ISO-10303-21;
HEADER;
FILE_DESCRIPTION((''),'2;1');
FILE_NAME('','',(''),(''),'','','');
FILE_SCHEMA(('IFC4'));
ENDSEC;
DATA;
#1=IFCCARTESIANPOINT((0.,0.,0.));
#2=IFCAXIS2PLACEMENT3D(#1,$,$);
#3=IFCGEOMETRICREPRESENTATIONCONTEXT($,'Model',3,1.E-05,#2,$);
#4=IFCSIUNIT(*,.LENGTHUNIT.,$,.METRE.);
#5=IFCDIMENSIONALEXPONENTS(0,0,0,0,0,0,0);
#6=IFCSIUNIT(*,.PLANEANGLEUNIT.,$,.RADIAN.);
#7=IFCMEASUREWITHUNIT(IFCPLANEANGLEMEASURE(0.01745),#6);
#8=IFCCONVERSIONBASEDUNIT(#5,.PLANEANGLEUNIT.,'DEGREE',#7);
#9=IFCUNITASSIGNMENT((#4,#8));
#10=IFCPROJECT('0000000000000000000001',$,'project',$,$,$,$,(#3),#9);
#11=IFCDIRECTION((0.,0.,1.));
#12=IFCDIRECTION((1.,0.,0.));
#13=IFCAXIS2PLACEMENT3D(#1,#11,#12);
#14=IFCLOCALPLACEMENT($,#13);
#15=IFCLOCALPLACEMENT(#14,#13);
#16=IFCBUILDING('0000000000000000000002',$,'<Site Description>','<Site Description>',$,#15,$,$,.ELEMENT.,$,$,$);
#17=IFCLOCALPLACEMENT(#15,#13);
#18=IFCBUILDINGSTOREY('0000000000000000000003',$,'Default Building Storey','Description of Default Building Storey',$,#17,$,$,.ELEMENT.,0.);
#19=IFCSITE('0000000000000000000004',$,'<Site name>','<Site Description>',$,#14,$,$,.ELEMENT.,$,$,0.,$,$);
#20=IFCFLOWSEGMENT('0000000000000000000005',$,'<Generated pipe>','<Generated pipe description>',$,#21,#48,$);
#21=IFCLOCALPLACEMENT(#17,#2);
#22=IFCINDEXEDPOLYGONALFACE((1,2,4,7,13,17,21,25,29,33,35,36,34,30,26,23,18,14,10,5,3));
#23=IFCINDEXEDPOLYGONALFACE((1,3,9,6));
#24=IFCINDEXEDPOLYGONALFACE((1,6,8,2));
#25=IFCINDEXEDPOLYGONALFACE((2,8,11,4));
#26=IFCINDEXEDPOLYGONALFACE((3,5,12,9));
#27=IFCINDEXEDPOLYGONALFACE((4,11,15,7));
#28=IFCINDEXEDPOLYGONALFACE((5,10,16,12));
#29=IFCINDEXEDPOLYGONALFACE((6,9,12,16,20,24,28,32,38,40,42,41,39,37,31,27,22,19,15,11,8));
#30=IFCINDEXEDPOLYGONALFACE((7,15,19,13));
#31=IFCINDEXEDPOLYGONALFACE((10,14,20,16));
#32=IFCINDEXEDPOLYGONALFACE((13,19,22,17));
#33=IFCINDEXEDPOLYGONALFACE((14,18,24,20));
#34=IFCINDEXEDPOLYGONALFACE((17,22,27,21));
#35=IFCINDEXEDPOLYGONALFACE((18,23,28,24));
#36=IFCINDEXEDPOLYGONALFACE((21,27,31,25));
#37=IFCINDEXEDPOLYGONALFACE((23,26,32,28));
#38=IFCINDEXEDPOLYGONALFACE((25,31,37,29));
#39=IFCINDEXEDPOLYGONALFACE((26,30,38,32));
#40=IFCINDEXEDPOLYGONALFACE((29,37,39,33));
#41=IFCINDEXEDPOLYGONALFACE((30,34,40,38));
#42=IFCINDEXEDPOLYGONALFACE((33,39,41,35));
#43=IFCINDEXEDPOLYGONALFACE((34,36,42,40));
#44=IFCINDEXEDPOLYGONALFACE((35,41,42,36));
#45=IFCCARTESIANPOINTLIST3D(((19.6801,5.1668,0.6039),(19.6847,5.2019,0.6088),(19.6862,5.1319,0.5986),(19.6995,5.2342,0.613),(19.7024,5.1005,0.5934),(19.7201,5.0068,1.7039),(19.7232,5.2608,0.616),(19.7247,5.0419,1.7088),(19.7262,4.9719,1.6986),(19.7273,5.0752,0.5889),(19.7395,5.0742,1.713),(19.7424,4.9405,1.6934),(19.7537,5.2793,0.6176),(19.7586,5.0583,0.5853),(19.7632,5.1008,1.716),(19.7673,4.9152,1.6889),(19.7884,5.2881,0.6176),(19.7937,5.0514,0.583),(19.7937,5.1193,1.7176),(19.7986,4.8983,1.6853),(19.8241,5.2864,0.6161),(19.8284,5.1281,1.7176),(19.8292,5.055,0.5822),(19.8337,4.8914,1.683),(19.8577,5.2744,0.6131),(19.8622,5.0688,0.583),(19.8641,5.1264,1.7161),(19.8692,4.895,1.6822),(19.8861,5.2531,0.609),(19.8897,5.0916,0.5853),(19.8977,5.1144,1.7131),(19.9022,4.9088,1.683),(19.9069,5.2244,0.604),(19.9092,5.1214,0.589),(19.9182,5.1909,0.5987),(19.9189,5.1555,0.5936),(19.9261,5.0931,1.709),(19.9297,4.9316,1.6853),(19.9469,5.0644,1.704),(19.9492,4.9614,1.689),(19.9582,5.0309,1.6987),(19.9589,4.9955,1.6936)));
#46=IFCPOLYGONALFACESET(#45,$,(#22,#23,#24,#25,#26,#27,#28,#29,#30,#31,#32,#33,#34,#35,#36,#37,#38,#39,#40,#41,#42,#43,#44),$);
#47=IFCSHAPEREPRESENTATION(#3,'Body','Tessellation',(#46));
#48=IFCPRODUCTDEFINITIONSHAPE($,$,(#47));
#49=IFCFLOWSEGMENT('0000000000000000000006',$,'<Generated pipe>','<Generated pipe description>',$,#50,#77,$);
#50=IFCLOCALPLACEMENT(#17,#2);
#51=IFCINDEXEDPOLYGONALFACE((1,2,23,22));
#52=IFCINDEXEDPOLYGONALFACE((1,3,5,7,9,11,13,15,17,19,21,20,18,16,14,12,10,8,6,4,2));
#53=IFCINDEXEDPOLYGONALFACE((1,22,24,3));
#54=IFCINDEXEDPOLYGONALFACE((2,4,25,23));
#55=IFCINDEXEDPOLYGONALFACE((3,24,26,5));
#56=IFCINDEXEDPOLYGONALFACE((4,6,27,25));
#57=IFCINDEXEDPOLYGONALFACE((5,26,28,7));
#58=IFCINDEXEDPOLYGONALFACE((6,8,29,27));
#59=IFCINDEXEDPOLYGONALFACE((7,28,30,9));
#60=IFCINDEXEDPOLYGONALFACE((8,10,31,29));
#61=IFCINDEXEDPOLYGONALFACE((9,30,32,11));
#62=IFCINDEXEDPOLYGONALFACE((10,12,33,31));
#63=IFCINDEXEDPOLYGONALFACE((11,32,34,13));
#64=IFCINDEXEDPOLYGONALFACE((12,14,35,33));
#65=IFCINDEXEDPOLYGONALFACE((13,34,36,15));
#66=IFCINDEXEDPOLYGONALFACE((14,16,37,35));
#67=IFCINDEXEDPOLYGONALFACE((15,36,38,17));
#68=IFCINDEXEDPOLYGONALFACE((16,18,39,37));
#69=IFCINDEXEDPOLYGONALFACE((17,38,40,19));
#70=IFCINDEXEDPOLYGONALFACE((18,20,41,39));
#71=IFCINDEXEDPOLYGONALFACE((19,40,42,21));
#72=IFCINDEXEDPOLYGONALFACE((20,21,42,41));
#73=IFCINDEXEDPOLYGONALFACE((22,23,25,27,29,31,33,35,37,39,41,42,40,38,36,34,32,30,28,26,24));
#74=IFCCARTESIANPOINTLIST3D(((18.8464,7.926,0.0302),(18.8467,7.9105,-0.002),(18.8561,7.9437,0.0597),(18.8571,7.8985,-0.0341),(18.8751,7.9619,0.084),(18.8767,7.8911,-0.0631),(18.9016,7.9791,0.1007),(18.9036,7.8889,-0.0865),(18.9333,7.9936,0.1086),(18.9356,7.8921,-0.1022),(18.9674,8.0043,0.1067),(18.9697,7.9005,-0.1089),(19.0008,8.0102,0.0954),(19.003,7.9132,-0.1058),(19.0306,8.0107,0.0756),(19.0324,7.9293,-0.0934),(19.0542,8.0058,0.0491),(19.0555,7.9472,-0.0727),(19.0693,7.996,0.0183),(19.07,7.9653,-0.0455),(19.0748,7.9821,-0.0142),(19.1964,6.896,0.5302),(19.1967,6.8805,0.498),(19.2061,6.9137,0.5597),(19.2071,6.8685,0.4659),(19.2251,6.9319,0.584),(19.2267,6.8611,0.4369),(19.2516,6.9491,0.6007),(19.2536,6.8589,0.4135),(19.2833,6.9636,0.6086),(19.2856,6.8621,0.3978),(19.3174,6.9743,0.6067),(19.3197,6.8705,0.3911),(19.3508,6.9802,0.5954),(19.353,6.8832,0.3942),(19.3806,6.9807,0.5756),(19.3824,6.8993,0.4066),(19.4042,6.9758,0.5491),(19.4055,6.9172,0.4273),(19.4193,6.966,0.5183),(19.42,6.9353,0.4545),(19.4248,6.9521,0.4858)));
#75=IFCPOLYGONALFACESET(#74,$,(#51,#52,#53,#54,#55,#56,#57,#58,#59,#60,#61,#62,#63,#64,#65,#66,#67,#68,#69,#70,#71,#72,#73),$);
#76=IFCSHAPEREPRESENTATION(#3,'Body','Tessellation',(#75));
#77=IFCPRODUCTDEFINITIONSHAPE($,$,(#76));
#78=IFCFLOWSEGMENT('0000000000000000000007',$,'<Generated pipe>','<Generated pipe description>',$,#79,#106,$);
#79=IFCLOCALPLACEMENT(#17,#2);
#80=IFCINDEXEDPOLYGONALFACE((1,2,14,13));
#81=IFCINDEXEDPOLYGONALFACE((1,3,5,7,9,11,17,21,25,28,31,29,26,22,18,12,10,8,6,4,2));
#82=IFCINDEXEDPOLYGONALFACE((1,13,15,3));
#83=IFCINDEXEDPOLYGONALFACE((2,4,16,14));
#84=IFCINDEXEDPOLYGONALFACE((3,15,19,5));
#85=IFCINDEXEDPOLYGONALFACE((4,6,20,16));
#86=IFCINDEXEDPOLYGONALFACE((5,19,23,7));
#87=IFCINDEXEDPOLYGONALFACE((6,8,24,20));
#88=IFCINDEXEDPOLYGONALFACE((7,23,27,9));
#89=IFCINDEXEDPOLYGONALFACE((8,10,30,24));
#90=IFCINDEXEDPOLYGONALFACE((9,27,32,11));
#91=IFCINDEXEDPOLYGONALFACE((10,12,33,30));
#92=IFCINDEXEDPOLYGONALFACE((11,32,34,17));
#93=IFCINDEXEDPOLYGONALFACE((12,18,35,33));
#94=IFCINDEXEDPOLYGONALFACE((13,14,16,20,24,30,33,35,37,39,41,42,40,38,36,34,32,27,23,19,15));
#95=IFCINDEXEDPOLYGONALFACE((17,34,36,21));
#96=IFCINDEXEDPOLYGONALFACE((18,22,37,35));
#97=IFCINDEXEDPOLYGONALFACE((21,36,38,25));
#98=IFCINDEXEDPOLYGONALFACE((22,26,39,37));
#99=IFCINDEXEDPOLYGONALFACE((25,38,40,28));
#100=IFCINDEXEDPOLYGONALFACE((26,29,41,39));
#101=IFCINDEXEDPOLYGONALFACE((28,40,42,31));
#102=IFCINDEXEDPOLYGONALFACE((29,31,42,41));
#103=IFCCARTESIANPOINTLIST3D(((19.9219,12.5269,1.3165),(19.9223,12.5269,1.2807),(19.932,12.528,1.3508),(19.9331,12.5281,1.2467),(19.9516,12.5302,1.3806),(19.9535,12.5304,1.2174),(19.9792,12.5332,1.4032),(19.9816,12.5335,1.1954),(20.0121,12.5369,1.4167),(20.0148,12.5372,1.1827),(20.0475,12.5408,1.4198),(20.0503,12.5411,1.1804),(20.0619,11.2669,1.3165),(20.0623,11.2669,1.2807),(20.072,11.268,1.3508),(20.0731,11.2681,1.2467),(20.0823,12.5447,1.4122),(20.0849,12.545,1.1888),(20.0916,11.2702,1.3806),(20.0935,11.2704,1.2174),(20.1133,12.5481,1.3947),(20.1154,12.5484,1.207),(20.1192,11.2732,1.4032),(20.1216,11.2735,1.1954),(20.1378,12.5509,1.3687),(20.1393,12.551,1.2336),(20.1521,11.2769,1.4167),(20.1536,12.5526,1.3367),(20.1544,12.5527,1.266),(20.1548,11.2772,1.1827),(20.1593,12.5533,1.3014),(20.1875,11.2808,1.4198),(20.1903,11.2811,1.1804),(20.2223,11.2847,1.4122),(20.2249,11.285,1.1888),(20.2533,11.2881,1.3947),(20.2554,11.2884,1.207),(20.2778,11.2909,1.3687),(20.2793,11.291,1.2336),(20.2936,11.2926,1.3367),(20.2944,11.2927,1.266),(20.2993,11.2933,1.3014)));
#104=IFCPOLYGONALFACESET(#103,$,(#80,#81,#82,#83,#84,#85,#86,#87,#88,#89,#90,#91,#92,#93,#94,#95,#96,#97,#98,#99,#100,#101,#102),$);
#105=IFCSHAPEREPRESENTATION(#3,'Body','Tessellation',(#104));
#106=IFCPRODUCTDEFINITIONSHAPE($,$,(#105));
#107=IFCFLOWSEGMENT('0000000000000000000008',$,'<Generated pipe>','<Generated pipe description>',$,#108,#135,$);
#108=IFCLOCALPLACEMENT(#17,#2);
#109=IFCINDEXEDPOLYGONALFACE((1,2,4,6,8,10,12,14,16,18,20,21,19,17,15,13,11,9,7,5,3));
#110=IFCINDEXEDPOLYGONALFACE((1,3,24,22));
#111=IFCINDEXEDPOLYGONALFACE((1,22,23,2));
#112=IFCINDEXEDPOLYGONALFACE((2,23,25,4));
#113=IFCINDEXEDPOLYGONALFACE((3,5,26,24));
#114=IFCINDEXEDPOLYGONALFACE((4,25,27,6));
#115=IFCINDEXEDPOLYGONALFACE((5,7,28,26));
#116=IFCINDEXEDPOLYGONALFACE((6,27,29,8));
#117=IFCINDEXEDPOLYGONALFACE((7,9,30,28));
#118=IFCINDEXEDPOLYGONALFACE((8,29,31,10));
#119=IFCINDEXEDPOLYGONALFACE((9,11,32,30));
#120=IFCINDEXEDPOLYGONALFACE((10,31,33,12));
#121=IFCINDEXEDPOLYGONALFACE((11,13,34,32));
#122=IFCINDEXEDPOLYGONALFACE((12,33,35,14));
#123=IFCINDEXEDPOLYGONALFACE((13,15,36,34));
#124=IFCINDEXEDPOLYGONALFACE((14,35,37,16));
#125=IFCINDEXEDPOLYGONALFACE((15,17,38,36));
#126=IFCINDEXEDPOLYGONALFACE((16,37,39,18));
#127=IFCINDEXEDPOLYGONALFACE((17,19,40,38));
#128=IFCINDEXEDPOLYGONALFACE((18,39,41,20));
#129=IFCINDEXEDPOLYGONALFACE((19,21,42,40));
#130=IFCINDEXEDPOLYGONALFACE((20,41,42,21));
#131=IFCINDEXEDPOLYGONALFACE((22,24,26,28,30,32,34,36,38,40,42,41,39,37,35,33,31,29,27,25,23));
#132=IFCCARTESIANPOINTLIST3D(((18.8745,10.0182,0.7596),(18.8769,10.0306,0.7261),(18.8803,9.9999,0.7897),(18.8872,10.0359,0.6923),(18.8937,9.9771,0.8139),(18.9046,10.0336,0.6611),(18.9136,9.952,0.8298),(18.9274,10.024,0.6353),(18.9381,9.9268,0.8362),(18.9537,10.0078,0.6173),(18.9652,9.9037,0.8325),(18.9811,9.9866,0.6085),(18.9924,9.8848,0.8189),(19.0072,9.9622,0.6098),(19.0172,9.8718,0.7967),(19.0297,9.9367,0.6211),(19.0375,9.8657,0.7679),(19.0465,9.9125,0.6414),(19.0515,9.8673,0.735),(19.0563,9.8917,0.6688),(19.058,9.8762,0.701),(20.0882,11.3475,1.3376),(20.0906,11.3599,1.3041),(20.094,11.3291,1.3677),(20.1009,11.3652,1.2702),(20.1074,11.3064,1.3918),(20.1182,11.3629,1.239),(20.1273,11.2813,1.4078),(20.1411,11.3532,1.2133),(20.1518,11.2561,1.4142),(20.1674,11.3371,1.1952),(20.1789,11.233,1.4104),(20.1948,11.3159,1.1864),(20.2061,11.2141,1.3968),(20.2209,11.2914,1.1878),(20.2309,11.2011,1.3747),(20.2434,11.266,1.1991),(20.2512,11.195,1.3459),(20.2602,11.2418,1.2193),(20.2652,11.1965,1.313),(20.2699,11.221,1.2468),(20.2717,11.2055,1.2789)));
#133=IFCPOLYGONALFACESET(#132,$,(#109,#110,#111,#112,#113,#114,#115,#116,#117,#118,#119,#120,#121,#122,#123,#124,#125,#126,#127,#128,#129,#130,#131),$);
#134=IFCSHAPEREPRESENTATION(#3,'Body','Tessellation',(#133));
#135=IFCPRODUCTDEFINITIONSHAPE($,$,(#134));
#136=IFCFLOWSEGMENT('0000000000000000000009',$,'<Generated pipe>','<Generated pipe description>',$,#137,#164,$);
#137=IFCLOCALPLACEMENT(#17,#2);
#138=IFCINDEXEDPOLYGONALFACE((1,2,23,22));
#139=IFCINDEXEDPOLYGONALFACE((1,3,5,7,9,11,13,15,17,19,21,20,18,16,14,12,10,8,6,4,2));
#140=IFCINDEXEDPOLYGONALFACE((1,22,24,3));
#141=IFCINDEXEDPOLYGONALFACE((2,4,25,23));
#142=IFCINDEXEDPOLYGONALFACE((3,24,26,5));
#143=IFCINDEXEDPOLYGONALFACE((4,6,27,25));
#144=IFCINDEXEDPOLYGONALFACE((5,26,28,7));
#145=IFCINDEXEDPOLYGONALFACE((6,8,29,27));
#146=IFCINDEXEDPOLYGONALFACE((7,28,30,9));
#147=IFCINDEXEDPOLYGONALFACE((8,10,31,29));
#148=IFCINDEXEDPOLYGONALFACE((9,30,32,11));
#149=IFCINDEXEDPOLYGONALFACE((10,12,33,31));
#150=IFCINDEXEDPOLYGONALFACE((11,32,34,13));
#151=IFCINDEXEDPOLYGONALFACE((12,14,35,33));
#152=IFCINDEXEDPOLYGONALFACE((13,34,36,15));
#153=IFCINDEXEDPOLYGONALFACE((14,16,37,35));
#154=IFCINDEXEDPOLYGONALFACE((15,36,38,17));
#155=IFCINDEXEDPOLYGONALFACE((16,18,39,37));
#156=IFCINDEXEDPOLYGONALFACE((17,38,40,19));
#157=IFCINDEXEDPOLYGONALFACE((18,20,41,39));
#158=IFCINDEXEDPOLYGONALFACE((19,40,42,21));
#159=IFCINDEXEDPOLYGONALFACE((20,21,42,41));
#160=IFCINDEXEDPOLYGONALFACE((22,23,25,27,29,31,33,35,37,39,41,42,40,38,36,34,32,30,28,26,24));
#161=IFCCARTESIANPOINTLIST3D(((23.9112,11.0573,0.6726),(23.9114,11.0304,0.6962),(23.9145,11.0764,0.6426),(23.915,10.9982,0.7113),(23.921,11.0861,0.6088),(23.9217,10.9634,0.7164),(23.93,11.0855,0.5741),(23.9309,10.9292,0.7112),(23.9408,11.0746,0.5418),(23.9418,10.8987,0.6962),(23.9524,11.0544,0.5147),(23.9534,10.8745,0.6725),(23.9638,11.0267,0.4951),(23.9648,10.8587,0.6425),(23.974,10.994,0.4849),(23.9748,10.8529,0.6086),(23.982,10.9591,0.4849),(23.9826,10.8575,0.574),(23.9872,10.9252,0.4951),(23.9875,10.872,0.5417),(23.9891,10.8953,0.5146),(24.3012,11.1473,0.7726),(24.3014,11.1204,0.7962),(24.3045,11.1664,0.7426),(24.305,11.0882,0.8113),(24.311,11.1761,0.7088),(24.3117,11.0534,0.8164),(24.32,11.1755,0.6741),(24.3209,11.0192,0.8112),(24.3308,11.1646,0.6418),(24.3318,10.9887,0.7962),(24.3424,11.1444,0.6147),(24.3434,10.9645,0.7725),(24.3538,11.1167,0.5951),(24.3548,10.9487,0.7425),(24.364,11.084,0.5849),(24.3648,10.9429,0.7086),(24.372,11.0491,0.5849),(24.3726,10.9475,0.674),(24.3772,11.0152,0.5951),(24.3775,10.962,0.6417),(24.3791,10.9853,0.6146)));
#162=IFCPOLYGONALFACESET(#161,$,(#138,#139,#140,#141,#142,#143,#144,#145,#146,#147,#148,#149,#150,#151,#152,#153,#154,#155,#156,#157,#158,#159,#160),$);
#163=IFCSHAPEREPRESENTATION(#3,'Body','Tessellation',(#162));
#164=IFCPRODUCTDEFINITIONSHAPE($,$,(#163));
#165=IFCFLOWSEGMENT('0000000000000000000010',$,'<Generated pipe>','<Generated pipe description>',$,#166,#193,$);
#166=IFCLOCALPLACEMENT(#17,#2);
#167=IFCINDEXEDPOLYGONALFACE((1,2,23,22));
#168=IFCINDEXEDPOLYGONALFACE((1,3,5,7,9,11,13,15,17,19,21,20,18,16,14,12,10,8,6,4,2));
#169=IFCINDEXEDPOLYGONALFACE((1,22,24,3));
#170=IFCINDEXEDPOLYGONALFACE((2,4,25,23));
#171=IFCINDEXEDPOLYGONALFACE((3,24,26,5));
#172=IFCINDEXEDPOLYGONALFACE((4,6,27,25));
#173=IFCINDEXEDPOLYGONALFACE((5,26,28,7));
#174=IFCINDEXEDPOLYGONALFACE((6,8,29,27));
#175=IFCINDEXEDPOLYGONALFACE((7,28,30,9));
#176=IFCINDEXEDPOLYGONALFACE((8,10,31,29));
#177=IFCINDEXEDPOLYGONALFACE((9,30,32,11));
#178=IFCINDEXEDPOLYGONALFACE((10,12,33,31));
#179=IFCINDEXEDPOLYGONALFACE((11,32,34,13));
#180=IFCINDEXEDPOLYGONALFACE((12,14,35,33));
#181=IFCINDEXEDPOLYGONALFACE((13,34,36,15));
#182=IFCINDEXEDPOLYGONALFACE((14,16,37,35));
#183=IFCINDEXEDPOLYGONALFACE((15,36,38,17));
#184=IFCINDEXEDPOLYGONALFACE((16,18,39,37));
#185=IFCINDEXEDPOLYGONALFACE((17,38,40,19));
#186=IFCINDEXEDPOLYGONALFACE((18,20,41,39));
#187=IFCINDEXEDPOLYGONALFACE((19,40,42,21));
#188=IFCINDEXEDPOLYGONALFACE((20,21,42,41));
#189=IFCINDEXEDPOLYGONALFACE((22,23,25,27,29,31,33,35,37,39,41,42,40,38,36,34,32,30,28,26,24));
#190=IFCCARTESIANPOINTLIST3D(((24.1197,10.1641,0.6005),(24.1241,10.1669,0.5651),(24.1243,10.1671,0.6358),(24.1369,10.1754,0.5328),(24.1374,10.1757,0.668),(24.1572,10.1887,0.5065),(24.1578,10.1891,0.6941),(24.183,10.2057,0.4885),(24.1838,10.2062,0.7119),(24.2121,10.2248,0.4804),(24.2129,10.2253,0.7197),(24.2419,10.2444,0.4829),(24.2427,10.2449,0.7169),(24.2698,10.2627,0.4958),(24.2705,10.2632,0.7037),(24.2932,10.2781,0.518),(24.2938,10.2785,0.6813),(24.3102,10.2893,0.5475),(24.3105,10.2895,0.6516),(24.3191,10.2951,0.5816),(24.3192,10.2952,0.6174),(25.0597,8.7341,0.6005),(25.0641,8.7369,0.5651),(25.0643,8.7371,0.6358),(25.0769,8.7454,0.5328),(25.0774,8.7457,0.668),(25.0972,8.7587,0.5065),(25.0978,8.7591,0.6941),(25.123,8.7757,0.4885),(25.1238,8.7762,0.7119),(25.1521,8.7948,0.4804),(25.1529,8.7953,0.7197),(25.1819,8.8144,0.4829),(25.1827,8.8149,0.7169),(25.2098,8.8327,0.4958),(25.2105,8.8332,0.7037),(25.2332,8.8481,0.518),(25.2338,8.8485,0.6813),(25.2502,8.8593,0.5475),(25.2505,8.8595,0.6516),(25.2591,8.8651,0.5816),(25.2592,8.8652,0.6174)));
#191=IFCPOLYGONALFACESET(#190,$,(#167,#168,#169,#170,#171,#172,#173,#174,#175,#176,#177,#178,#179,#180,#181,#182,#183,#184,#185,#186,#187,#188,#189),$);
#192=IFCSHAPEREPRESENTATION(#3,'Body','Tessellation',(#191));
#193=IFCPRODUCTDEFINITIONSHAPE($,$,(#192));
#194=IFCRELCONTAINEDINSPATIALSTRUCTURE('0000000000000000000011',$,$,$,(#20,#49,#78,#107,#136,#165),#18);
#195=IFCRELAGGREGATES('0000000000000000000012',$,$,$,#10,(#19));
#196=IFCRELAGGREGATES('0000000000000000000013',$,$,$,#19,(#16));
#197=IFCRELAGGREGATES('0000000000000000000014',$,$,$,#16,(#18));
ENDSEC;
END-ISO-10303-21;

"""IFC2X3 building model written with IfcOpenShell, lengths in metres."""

from ifc_helpers import new_model, entity, si_unit, converted_unit, frame, origin, origin_with_axes, origin_2d_with_axis, place, context, project, spatial, circle, extrude, element, save


model = new_model("IFC2X3")

# Units and contexts
model_context = context("Model", 3, precision=1e-05, world=origin())
ifc_project = project(units=[si_unit("LENGTHUNIT", "METRE"), converted_unit("PLANEANGLEUNIT", "DEGREE", entity("IfcPlaneAngleMeasure", 0.01745), si_unit("PLANEANGLEUNIT", "RADIAN"), dimensions=[0, 0, 0, 0, 0, 0, 0])], contexts=[model_context])

# Site, building, storey
site_placement = place(None, origin_with_axes())
site = spatial("IfcSite", under=ifc_project, at=site_placement, Name="<Site name>", Description="<Site Description>", CompositionType="ELEMENT", RefElevation=0.0)
building_placement = place(site_placement, origin_with_axes())
building = spatial("IfcBuilding", under=site, at=building_placement, Name="<Site Description>", Description="<Site Description>", CompositionType="ELEMENT")
storey_placement = place(building_placement, origin_with_axes())
storey = spatial("IfcBuildingStorey", under=building, at=storey_placement, Name="Default Building Storey", Description="Description of Default Building Storey", CompositionType="ELEMENT", Elevation=0.0)

# Flow segments
flow_segment_1_placement = place(storey_placement, frame((19.84, 5.01, 1.7), z_axis=(-0.035962, 0.143847, -0.988946), x_axis=(0.984686, 0.17402, -0.010495)))
element("IfcFlowSegment", 1, at=flow_segment_1_placement, inside=storey, Name="<Generated pipe>", Description="<Generated pipe description>", context=model_context, shape_type="SweptSolid", body=[
    extrude(circle(Radius=0.12, at=origin_2d_with_axis()), origin_with_axes(), (0.0, 0.0, 1.0), 1.1123),
])
flow_segment_2_placement = place(storey_placement, frame((19.31, 6.92, 0.5), z_axis=(-0.292337, 0.860307, -0.417625), x_axis=(0.910945, 0.383426, 0.152197)))
element("IfcFlowSegment", 2, at=flow_segment_2_placement, inside=storey, Name="<Generated pipe>", Description="<Generated pipe description>", context=model_context, shape_type="SweptSolid", body=[
    extrude(circle(Radius=0.12, at=origin_2d_with_axis()), origin_with_axes(), (0.0, 0.0, 1.0), 1.1972),
])
flow_segment_3_placement = place(storey_placement, frame((20.04, 12.54, 1.3), z_axis=(0.110432, -0.993884, 0.0), x_axis=(0.610667, 0.067852, 0.788975)))
element("IfcFlowSegment", 3, at=flow_segment_3_placement, inside=storey, Name="<Generated pipe>", Description="<Generated pipe description>", context=model_context, shape_type="SweptSolid", body=[
    extrude(circle(Radius=0.12, at=origin_2d_with_axis()), origin_with_axes(), (0.0, 0.0, 1.0), 1.2678),
])
flow_segment_4_placement = place(storey_placement, frame((20.18, 11.28, 1.3), z_axis=(-0.641989, -0.703131, -0.305709), x_axis=(-0.439527, 0.010801, 0.898164)))
element("IfcFlowSegment", 4, at=flow_segment_4_placement, inside=storey, Name="<Generated pipe>", Description="<Generated pipe description>", context=model_context, shape_type="SweptSolid", body=[
    extrude(circle(Radius=0.12, at=origin_2d_with_axis()), origin_with_axes(), (0.0, 0.0, 1.0), 1.8905),
])
flow_segment_5_placement = place(storey_placement, frame((24.34, 11.06, 0.7), z_axis=(-0.945333, -0.218154, -0.242393), x_axis=(-0.321788, 0.503453, 0.801865)))
element("IfcFlowSegment", 5, at=flow_segment_5_placement, inside=storey, Name="<Generated pipe>", Description="<Generated pipe description>", context=model_context, shape_type="SweptSolid", body=[
    extrude(circle(Radius=0.12, at=origin_2d_with_axis()), origin_with_axes(), (0.0, 0.0, 1.0), 0.4126),
])
flow_segment_6_placement = place(storey_placement, frame((24.22, 10.23, 0.6), z_axis=(0.549294, -0.835629, 0.0), x_axis=(0.614928, 0.404219, 0.677105)))
element("IfcFlowSegment", 6, at=flow_segment_6_placement, inside=storey, Name="<Generated pipe>", Description="<Generated pipe description>", context=model_context, shape_type="SweptSolid", body=[
    extrude(circle(Radius=0.12, at=origin_2d_with_axis()), origin_with_axes(), (0.0, 0.0, 1.0), 1.7113),
])

save(model, "model.ifc")
